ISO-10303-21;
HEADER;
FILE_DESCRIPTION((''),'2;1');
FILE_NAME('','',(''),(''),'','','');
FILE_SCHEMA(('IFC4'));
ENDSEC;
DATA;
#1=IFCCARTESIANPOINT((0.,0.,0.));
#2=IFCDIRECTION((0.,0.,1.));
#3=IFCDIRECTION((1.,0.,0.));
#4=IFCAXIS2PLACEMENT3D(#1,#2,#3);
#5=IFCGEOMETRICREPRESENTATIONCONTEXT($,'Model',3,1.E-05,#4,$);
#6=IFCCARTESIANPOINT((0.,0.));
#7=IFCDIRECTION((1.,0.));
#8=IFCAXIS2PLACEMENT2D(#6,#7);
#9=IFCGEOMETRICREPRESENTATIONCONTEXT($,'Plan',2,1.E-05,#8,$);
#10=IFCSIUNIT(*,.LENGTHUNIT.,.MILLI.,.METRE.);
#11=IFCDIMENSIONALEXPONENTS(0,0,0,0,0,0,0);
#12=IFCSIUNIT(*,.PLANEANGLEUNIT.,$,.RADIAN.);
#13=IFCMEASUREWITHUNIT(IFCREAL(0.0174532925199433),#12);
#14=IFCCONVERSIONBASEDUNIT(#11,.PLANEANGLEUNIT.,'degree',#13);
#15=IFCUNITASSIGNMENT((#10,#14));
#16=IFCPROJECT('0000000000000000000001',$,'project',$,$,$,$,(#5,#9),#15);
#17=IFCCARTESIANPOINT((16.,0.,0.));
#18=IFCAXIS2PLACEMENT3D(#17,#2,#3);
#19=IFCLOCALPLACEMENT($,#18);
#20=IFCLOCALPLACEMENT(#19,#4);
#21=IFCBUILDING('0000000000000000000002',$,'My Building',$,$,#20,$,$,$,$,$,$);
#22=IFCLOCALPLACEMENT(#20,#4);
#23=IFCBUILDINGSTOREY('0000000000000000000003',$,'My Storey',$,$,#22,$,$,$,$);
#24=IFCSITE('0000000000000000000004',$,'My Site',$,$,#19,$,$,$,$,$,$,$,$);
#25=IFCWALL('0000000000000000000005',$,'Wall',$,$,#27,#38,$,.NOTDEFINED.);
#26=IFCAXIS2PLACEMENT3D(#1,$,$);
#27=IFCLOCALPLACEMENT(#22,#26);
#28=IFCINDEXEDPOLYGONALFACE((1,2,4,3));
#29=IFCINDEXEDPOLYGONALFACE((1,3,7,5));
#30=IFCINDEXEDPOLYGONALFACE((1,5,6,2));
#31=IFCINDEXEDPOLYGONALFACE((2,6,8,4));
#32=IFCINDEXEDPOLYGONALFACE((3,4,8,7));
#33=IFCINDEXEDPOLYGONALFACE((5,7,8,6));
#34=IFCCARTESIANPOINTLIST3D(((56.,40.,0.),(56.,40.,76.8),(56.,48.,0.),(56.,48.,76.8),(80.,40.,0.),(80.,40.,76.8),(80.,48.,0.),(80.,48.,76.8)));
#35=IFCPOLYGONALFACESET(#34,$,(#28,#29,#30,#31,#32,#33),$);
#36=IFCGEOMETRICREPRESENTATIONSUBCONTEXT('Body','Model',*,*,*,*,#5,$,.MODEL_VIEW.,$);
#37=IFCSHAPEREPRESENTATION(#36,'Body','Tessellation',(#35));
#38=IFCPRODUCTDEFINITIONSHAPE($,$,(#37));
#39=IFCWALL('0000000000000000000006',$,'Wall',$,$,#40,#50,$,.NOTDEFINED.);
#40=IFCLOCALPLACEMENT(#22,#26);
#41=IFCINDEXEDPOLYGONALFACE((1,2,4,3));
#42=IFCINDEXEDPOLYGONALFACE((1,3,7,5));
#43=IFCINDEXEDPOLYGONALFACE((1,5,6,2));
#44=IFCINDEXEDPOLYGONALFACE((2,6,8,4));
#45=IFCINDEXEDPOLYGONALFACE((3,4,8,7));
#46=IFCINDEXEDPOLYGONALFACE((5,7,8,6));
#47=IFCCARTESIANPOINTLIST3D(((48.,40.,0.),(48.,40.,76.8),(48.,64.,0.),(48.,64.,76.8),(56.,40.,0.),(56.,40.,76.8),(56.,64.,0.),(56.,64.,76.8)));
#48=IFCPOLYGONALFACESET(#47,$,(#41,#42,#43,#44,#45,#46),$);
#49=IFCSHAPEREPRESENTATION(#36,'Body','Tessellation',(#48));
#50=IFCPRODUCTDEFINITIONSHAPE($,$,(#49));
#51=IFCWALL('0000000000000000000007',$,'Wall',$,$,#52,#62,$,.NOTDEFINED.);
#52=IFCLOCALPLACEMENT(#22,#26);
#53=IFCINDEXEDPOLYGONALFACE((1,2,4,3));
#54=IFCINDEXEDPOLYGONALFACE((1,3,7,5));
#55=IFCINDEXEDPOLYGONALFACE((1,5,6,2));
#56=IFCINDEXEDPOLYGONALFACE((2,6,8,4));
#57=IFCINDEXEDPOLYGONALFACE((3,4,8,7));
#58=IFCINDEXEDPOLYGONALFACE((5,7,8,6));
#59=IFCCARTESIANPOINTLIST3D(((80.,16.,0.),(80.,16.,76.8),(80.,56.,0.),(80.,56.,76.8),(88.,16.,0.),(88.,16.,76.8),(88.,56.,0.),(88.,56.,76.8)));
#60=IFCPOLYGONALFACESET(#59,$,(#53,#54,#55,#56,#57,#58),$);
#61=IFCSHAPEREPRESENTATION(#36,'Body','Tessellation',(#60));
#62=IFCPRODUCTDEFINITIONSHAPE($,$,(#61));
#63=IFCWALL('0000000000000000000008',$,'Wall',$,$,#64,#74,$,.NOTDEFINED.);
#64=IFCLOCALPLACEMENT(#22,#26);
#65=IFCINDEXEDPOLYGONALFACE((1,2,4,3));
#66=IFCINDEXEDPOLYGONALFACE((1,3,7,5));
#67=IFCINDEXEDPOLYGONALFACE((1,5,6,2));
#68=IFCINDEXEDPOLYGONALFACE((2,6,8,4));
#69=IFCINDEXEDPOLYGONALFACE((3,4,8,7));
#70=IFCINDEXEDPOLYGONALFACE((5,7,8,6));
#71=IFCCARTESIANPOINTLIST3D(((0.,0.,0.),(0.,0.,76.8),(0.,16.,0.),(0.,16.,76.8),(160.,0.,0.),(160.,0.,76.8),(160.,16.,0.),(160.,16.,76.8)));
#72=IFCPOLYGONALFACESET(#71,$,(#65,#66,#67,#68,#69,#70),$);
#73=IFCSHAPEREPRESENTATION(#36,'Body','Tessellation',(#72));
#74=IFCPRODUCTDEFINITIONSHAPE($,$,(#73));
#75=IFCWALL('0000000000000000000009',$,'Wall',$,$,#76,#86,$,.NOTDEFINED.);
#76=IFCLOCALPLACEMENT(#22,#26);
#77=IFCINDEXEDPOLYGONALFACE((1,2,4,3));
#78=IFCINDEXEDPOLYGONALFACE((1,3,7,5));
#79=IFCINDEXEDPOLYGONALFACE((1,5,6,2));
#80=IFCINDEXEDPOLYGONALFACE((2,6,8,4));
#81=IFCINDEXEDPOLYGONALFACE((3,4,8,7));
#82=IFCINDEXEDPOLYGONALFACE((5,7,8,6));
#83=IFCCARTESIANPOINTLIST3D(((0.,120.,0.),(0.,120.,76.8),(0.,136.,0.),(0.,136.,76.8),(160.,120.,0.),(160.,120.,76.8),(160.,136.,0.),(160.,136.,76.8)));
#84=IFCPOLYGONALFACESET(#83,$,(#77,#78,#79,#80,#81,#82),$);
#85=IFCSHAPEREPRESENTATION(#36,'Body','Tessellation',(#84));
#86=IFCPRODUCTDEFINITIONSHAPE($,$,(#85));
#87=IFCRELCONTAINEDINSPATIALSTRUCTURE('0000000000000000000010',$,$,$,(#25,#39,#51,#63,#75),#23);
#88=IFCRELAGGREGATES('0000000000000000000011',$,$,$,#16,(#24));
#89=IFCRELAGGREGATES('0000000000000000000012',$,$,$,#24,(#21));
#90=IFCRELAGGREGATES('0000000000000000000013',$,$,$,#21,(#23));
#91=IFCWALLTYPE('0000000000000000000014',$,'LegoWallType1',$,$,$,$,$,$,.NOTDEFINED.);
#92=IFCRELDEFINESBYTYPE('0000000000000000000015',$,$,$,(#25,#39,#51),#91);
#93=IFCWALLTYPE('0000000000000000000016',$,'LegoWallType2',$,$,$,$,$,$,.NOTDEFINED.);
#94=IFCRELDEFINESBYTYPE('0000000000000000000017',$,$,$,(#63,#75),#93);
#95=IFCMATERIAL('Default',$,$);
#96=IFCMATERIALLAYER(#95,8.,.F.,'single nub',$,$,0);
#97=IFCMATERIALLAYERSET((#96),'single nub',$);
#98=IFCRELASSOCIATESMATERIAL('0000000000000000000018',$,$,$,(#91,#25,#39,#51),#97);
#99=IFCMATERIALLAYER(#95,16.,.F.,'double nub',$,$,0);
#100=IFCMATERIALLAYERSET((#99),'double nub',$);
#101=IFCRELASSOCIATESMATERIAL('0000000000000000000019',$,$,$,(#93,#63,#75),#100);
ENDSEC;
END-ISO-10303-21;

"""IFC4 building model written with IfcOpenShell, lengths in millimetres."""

from ifc_helpers import new_model, entity, si_unit, converted_unit, frame, origin_with_axes, origin_2d_with_axis, place, context, subcontext, project, spatial, indexed_curve, outline, extrude, material, layer, layer_set, layer_usage, type_object, element, save


model = new_model("IFC4")

# Units and contexts
model_context = context("Model", 3, precision=1e-05, world=origin_with_axes())
plan_context = context("Plan", 2, precision=1e-05, world=origin_2d_with_axis())
body_context = subcontext(model_context, "Body", "Model", "MODEL_VIEW")
ifc_project = project(units=[si_unit("LENGTHUNIT", "METRE", prefix="MILLI"), converted_unit("PLANEANGLEUNIT", "degree", entity("IfcReal", 0.0174532925199433), si_unit("PLANEANGLEUNIT", "RADIAN"), dimensions=[0, 0, 0, 0, 0, 0, 0])], contexts=[model_context, plan_context])

# Site, building, storey
site_placement = place(None, frame((16.0, 0.0, 0.0), z_axis=(0.0, 0.0, 1.0), x_axis=(1.0, 0.0, 0.0)))
site = spatial("IfcSite", under=ifc_project, at=site_placement, Name="My Site")
building_placement = place(site_placement, origin_with_axes())
building = spatial("IfcBuilding", under=site, at=building_placement, Name="My Building")
storey_placement = place(building_placement, origin_with_axes())
storey = spatial("IfcBuildingStorey", under=building, at=storey_placement, Name="My Storey")

# Walls
ifc_material = material(Name="Default")
ifc_layer_1 = layer(ifc_material, 8.0, ventilated=False, Name="single nub", Priority=0)
ifc_layer_set_1 = layer_set([ifc_layer_1], Name="single nub")
ifc_layer_usage_1 = layer_usage(ifc_layer_set_1, "AXIS2", "POSITIVE", 0.0)
wall_type_1 = type_object("IfcWallType", Name="LegoWallType1", PredefinedType="NOTDEFINED", material=ifc_layer_set_1)
wall_1_placement = place(storey_placement, frame((56.0, 40.0, 0.0), z_axis=(0.0, 0.0, 1.0), x_axis=(1.0, 0.0, 0.0)))
element("IfcWall", 1, at=wall_1_placement, inside=storey, type_object=wall_type_1, material=ifc_layer_usage_1, Name="Wall", PredefinedType="NOTDEFINED", context=body_context, shape_type="SweptSolid", body=[
    extrude(outline(indexed_curve([(0.0, 0.0), (0.0, 8.0), (24.0, 8.0), (24.0, 0.0), (0.0, 0.0)], self_intersect=False)), origin_with_axes(), (0.0, 0.0, 1.0), 76.8),
])
ifc_layer_usage_2 = layer_usage(ifc_layer_set_1, "AXIS2", "POSITIVE", 0.0)
wall_2_placement = place(storey_placement, frame((56.0, 40.0, 0.0), z_axis=(0.0, 0.0, 1.0), x_axis=(0.000001, 1.0, 0.0)))
element("IfcWall", 2, at=wall_2_placement, inside=storey, type_object=wall_type_1, material=ifc_layer_usage_2, Name="Wall", PredefinedType="NOTDEFINED", context=body_context, shape_type="SweptSolid", body=[
    extrude(outline(indexed_curve([(0.0, 0.0), (0.0, 8.0), (24.0, 8.0), (24.0, 0.0), (0.0, 0.0)], self_intersect=False)), origin_with_axes(), (0.0, 0.0, 1.0), 76.8),
])
ifc_layer_usage_3 = layer_usage(ifc_layer_set_1, "AXIS2", "POSITIVE", 0.0)
wall_3_placement = place(storey_placement, frame((88.0, 16.0, 0.0), z_axis=(0.0, 0.0, 1.0), x_axis=(0.000001, 1.0, 0.0)))
element("IfcWall", 3, at=wall_3_placement, inside=storey, type_object=wall_type_1, material=ifc_layer_usage_3, Name="Wall", PredefinedType="NOTDEFINED", context=body_context, shape_type="SweptSolid", body=[
    extrude(outline(indexed_curve([(0.0, 0.0), (0.0, 8.0), (40.0, 8.0), (40.0, 0.0), (0.0, 0.0)], self_intersect=False)), origin_with_axes(), (0.0, 0.0, 1.0), 76.8),
])
ifc_layer_2 = layer(ifc_material, 16.0, ventilated=False, Name="double nub", Priority=0)
ifc_layer_set_2 = layer_set([ifc_layer_2], Name="double nub")
ifc_layer_usage_4 = layer_usage(ifc_layer_set_2, "AXIS2", "POSITIVE", 0.0)
wall_type_2 = type_object("IfcWallType", Name="LegoWallType2", PredefinedType="NOTDEFINED", material=ifc_layer_set_2)
wall_4_placement = place(storey_placement, origin_with_axes())
element("IfcWall", 4, at=wall_4_placement, inside=storey, type_object=wall_type_2, material=ifc_layer_usage_4, Name="Wall", PredefinedType="NOTDEFINED", context=body_context, shape_type="SweptSolid", body=[
    extrude(outline(indexed_curve([(0.0, 0.0), (0.0, 16.0), (160.0, 16.0), (160.0, 0.0), (0.0, 0.0)], self_intersect=False)), origin_with_axes(), (0.0, 0.0, 1.0), 76.8),
])
ifc_layer_usage_5 = layer_usage(ifc_layer_set_2, "AXIS2", "POSITIVE", 0.0)
wall_5_placement = place(storey_placement, frame((0.0, 120.0, 0.0), z_axis=(0.0, 0.0, 1.0), x_axis=(1.0, -0.000001, 0.0)))
element("IfcWall", 5, at=wall_5_placement, inside=storey, type_object=wall_type_2, material=ifc_layer_usage_5, Name="Wall", PredefinedType="NOTDEFINED", context=body_context, shape_type="SweptSolid", body=[
    extrude(outline(indexed_curve([(0.0, 0.0), (0.0, 16.0), (160.0, 16.0), (160.0, 0.0), (0.0, 0.0)], self_intersect=False)), origin_with_axes(), (0.0, 0.0, 1.0), 76.8),
])

save(model, "model.ifc")
